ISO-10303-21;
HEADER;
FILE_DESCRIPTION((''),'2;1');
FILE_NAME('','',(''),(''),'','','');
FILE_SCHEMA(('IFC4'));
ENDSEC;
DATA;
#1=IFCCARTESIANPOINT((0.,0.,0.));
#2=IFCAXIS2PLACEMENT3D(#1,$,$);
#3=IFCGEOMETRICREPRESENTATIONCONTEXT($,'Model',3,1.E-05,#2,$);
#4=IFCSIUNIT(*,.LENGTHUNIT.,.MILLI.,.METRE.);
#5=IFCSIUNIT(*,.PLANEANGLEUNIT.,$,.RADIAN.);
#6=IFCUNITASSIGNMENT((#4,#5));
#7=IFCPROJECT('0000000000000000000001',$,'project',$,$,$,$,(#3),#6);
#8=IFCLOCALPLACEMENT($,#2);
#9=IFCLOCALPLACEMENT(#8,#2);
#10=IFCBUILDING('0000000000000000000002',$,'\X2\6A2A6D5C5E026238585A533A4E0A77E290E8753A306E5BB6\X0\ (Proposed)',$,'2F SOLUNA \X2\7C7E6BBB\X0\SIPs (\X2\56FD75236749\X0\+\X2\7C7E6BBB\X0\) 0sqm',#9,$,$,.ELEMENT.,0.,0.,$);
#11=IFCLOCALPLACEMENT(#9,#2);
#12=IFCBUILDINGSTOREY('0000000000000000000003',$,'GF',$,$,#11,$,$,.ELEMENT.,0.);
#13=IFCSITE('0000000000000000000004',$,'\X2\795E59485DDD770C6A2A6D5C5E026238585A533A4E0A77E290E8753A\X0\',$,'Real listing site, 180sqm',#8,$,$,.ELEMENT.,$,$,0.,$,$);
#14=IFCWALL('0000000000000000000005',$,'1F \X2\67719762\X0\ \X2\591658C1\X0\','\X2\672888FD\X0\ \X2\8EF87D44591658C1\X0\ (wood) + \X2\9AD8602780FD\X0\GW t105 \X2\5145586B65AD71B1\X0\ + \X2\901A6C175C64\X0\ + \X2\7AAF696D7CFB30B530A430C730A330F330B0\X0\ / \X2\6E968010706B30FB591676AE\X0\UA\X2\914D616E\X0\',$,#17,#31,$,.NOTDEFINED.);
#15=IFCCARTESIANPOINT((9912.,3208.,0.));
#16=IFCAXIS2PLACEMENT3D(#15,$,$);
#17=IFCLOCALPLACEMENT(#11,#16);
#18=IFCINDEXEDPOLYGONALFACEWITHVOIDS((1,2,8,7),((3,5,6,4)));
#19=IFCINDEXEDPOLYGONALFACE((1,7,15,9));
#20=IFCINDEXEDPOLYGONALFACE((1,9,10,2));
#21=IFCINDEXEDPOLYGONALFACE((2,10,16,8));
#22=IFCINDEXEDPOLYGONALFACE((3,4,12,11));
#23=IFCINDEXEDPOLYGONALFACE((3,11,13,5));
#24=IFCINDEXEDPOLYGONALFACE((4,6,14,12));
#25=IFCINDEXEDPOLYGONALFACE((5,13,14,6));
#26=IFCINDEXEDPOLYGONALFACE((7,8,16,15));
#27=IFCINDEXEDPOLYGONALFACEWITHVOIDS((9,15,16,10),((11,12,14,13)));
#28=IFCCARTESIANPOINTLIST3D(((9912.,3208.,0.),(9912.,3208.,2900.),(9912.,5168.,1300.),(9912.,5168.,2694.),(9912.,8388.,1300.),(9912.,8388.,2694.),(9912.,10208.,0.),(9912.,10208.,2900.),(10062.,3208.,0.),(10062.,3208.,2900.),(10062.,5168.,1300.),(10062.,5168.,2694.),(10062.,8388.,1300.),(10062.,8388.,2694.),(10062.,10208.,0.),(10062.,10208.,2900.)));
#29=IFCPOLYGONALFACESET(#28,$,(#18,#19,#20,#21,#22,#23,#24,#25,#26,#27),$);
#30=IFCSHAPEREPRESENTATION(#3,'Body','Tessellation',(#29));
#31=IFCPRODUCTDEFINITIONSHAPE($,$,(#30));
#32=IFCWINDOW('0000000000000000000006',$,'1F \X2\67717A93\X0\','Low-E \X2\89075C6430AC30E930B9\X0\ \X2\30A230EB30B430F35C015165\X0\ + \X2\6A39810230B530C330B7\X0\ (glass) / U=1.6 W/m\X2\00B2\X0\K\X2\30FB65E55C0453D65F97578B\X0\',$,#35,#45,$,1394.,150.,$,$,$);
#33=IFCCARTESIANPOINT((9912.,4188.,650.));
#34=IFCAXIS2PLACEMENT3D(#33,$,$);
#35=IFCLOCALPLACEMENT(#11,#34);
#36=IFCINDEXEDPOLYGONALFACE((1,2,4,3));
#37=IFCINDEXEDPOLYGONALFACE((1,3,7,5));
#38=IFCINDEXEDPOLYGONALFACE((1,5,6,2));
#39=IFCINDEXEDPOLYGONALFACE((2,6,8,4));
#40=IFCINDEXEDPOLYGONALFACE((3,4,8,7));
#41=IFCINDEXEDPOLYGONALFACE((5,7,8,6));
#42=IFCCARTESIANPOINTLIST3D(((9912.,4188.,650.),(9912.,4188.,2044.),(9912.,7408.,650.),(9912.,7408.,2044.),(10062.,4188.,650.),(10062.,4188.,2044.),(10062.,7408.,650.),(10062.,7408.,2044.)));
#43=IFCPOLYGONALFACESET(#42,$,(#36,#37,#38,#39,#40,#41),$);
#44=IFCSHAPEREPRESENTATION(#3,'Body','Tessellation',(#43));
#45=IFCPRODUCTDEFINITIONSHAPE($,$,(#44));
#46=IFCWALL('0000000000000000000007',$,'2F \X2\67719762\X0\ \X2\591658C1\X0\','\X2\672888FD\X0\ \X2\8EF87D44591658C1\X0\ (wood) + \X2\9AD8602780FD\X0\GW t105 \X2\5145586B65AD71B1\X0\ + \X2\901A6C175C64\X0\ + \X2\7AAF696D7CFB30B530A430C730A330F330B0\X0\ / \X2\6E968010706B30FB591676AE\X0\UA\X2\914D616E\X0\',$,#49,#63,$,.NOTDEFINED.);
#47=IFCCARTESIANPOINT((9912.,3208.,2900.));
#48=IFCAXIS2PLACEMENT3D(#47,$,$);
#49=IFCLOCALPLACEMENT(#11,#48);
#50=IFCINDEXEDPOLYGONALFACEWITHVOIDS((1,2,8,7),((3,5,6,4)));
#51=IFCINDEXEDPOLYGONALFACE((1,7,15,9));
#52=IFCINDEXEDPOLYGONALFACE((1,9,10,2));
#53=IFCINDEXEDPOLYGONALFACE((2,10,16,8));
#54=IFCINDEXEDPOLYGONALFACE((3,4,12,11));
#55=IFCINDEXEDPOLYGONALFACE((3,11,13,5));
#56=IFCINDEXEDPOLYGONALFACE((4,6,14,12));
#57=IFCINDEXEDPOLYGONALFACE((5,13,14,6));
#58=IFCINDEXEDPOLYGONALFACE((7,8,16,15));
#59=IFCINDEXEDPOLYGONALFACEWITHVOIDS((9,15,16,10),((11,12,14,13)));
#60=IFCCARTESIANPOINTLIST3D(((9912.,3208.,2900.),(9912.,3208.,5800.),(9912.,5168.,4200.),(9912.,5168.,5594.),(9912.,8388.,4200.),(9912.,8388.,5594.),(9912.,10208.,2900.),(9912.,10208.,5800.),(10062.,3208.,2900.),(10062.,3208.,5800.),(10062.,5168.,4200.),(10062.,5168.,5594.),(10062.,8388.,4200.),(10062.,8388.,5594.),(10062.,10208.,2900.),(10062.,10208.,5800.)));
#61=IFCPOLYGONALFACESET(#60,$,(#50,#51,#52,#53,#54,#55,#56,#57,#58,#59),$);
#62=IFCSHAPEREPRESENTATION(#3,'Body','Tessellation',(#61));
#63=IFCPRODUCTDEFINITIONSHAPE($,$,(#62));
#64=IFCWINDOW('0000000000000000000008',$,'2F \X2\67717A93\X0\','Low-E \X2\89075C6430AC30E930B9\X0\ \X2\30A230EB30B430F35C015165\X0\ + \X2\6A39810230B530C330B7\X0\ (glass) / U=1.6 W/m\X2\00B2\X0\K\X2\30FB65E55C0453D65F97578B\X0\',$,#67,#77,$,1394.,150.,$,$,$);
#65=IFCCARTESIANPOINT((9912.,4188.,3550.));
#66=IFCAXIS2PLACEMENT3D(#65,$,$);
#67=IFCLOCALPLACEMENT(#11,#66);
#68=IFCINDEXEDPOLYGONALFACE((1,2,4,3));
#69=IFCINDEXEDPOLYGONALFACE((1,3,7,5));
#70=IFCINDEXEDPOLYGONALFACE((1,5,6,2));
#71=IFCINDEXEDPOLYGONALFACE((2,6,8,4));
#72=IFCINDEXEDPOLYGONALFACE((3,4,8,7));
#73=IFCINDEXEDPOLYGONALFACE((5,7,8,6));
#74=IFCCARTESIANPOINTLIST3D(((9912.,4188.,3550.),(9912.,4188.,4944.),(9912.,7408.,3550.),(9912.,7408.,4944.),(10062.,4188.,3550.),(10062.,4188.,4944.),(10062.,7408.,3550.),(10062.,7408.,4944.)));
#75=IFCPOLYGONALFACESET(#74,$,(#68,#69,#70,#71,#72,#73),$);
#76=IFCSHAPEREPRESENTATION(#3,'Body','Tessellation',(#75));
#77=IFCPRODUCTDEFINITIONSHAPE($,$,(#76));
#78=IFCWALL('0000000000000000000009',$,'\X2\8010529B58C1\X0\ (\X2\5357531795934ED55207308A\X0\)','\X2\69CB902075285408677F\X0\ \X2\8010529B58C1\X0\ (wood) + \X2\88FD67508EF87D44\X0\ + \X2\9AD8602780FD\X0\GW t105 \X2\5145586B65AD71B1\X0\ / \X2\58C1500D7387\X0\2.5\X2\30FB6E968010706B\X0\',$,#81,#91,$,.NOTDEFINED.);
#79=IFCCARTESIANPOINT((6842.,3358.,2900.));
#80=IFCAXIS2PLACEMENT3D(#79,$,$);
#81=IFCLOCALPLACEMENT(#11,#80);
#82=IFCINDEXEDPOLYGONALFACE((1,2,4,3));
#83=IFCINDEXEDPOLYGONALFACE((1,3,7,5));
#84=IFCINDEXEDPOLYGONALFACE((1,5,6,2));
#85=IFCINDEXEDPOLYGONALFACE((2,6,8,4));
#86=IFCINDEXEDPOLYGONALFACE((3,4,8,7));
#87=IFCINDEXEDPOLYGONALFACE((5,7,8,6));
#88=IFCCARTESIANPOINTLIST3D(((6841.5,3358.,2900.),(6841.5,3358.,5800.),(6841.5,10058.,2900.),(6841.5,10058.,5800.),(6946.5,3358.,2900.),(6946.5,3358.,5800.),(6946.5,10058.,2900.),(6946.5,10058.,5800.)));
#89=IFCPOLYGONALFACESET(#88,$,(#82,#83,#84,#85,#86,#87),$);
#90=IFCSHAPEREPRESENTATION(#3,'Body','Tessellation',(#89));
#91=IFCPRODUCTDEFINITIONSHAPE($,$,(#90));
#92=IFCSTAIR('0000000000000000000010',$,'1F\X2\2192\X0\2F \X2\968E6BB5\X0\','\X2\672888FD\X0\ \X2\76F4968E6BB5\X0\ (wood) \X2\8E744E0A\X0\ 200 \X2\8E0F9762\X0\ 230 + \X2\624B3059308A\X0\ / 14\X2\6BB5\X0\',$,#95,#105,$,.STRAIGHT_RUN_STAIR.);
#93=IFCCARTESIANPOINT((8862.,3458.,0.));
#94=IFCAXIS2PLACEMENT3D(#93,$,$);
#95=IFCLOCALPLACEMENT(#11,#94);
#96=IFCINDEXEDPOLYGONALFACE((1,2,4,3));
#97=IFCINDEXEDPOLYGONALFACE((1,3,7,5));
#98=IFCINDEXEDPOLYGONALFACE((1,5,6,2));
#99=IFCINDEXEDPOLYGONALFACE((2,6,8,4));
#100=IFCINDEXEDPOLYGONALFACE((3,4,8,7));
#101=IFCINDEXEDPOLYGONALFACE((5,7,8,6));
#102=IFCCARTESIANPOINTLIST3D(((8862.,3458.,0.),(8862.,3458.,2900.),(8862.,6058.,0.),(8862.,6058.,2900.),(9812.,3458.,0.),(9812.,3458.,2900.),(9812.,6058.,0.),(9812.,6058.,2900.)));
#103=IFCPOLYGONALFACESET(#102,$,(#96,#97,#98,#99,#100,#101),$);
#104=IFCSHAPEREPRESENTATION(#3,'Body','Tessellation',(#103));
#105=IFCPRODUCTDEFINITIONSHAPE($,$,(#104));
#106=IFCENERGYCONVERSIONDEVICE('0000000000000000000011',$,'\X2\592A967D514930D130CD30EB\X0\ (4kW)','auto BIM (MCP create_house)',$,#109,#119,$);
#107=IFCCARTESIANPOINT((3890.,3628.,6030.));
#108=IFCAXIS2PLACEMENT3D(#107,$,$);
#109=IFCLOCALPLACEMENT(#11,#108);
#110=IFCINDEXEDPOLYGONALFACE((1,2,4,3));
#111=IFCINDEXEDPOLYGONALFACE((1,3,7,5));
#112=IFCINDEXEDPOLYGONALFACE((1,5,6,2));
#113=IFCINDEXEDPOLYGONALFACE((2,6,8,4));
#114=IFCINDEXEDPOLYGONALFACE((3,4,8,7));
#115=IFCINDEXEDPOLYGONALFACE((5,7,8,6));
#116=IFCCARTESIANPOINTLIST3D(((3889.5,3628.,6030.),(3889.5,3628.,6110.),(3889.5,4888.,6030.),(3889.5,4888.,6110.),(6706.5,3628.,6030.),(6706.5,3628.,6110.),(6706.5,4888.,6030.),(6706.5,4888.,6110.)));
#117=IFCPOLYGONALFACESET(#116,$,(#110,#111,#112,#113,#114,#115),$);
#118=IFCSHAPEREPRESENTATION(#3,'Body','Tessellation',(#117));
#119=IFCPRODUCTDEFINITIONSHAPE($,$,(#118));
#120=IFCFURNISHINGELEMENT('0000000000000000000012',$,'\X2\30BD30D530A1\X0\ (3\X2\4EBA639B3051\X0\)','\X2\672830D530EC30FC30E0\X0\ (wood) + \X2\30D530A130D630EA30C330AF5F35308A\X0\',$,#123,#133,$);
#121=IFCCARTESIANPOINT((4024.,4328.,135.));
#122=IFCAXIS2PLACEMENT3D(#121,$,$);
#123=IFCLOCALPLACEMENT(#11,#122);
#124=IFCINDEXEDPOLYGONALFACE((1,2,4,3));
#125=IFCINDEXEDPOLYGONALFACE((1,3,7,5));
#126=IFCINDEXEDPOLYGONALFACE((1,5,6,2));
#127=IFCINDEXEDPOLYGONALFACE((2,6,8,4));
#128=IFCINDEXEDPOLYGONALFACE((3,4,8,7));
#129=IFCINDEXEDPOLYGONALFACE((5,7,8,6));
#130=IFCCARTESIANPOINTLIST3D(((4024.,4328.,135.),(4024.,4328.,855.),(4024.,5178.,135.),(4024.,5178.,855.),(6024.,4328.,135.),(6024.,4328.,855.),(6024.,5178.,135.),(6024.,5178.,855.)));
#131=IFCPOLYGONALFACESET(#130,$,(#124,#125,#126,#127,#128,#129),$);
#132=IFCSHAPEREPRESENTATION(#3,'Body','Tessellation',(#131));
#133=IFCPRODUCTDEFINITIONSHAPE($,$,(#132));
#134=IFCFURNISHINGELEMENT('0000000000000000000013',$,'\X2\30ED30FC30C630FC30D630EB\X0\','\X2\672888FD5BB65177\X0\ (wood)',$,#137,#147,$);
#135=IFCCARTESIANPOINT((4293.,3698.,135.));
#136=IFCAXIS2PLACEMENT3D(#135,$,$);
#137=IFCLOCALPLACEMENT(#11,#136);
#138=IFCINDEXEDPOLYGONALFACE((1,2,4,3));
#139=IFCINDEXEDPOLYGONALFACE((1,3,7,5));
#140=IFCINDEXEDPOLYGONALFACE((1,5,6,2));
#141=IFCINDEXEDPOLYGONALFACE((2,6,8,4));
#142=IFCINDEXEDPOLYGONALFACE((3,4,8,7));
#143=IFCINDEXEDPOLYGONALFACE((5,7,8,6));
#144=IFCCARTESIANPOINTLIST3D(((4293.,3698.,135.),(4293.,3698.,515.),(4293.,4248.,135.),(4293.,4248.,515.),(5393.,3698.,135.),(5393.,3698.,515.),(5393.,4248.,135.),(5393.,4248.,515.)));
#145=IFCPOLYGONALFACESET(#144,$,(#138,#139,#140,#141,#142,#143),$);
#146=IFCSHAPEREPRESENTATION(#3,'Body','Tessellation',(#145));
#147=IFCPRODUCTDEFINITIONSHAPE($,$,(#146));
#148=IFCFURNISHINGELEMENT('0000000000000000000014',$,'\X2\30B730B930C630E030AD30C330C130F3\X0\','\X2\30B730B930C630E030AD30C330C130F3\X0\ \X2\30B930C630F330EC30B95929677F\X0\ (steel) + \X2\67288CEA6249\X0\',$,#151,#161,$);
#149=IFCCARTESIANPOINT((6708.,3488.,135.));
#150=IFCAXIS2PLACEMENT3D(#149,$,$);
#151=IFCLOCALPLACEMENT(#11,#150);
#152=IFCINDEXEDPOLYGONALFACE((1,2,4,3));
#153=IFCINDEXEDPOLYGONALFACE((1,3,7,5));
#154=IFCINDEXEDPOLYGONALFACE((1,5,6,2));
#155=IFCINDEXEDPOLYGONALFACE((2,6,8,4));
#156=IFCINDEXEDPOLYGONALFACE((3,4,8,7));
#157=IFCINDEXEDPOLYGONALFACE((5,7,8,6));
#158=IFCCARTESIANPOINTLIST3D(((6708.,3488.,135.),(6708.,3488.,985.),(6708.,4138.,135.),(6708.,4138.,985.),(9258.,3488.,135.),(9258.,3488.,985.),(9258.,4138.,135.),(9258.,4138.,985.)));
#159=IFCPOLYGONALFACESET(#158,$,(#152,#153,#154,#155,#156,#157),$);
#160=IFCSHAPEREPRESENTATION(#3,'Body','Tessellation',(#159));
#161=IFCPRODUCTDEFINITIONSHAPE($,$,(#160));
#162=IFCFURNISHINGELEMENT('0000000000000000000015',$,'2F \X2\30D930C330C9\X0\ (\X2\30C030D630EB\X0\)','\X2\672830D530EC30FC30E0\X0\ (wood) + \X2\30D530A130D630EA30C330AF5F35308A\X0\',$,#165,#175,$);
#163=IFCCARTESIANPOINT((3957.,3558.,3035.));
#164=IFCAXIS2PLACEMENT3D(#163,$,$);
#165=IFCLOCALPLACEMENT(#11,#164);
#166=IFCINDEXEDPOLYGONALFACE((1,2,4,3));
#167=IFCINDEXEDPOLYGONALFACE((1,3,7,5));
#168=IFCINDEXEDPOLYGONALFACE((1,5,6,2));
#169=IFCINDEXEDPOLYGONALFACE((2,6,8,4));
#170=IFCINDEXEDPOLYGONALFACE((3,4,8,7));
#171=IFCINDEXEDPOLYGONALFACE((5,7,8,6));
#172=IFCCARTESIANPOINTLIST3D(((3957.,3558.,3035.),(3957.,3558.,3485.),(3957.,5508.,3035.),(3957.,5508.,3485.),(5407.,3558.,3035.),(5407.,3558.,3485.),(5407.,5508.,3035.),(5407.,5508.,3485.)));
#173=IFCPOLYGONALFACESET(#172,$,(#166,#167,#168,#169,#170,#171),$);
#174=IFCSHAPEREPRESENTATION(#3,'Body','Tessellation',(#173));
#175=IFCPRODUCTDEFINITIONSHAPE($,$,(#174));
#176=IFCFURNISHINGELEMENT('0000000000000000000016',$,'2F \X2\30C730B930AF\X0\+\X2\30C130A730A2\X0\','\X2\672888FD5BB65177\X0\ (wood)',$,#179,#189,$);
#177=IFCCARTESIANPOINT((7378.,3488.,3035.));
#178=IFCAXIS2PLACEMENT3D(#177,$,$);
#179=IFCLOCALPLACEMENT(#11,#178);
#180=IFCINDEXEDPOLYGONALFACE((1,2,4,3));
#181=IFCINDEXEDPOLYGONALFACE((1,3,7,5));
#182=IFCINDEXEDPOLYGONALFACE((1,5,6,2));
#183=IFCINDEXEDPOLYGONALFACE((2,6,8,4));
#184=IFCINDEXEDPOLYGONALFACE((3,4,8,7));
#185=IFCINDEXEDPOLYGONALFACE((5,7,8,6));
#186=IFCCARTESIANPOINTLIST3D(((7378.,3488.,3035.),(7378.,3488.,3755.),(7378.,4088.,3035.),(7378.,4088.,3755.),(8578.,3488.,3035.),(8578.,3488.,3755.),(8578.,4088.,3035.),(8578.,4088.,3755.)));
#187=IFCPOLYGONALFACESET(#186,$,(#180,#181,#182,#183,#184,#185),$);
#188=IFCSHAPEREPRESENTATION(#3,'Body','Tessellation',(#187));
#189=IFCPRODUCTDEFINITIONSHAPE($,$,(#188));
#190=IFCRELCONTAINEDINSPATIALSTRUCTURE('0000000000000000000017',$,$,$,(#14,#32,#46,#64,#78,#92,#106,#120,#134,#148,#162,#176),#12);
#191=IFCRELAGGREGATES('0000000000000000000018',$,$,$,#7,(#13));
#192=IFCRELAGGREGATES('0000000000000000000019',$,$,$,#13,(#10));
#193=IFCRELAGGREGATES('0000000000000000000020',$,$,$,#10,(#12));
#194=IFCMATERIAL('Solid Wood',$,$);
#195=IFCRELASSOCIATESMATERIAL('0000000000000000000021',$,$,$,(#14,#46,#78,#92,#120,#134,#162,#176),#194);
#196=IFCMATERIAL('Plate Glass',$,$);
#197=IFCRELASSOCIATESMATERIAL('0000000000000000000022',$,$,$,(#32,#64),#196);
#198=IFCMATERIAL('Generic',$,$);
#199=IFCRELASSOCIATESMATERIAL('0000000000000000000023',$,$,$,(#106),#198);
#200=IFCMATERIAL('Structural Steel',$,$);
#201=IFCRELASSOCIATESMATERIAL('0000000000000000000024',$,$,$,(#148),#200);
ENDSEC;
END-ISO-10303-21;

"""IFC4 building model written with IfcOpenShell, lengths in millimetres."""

from ifc_helpers import new_model, si_unit, frame, frame_2d, origin, place, context, project, spatial, rectangle, extrude, material, element, fill, save


model = new_model("IFC4")

# Units and contexts
model_context = context("Model", 3, precision=1e-05, world=origin())
ifc_project = project(units=[si_unit("LENGTHUNIT", "METRE", prefix="MILLI"), si_unit("PLANEANGLEUNIT", "RADIAN")], contexts=[model_context])

# Site, building, storey
site_placement = place(None, origin())
site = spatial("IfcSite", under=ifc_project, at=site_placement, Name="神奈川県横浜市戸塚区上矢部町", ObjectType="Real listing site, 180sqm", CompositionType="ELEMENT", RefElevation=0.0)
building_placement = place(site_placement, origin())
building = spatial("IfcBuilding", under=site, at=building_placement, Name="横浜市戸塚区上矢部町の家 (Proposed)", ObjectType="2F SOLUNA 籾殻SIPs (国産杉+籾殻) 0sqm", CompositionType="ELEMENT", ElevationOfRefHeight=0.0, ElevationOfTerrain=0.0)
storey_placement = place(building_placement, origin())
storey = spatial("IfcBuildingStorey", under=building, at=storey_placement, Name="GF", CompositionType="ELEMENT", Elevation=0.0)

# Wall, opening, window
ifc_material_1 = material(Name="Solid Wood")
wall_1_placement = place(storey_placement, frame((9912.0, 3208.0, 0.0)))
wall_1 = element("IfcWall", 1, at=wall_1_placement, inside=storey, material=ifc_material_1, Name="1F 東面 外壁", Description="木製 軸組外壁 (wood) + 高性能GW t105 充填断熱 + 通気層 + 窯業系サイディング / 準耐火・外皮UA配慮", PredefinedType="NOTDEFINED", context=model_context, shape_type="SweptSolid", body=[
    extrude(rectangle(XDim=150.0, YDim=7000.0, at=frame_2d((75.0, 3500.0))), frame((9912.0, 3208.0, 0.0)), (0.0, 0.0, 1.0), 2900.0),
])
opening_1_placement = place(storey_placement, frame((9912.0, 4188.0, 650.0)))
opening_1 = element("IfcOpeningElement", 2, at=opening_1_placement, cuts=wall_1, PredefinedType="NOTDEFINED", context=model_context, shape_type="SweptSolid", body=[
    extrude(rectangle(XDim=150.0, YDim=3220.0, at=frame_2d((75.0, 1610.0))), frame((9912.0, 4188.0, 650.0)), (0.0, 0.0, 1.0), 1394.0),
])
ifc_material_2 = material(Name="Plate Glass")
window_1_placement = place(storey_placement, frame((9912.0, 4188.0, 650.0)))
window_1 = element("IfcWindow", 3, at=window_1_placement, inside=storey, material=ifc_material_2, Name="1F 東窓", Description="Low-E 複層ガラス アルゴン封入 + 樹脂サッシ (glass) / U=1.6 W/m²K・日射取得型", OverallHeight=1394.0, OverallWidth=150.0, context=model_context, shape_type="SweptSolid", body=[
    extrude(rectangle(XDim=150.0, YDim=3220.0, at=frame_2d((75.0, 1610.0))), frame((9912.0, 4188.0, 650.0)), (0.0, 0.0, 1.0), 1394.0),
])
fill(opening_1, window_1)

# Wall, opening, window
wall_2_placement = place(storey_placement, frame((9912.0, 3208.0, 2900.0)))
wall_2 = element("IfcWall", 4, at=wall_2_placement, inside=storey, material=ifc_material_1, Name="2F 東面 外壁", Description="木製 軸組外壁 (wood) + 高性能GW t105 充填断熱 + 通気層 + 窯業系サイディング / 準耐火・外皮UA配慮", PredefinedType="NOTDEFINED", context=model_context, shape_type="SweptSolid", body=[
    extrude(rectangle(XDim=150.0, YDim=7000.0, at=frame_2d((75.0, 3500.0))), frame((9912.0, 3208.0, 2900.0)), (0.0, 0.0, 1.0), 2900.0),
])
opening_2_placement = place(storey_placement, frame((9912.0, 4188.0, 3550.0)))
opening_2 = element("IfcOpeningElement", 5, at=opening_2_placement, cuts=wall_2, PredefinedType="NOTDEFINED", context=model_context, shape_type="SweptSolid", body=[
    extrude(rectangle(XDim=150.0, YDim=3220.0, at=frame_2d((75.0, 1610.0))), frame((9912.0, 4188.0, 3550.0)), (0.0, 0.0, 1.0), 1394.0),
])
window_2_placement = place(storey_placement, frame((9912.0, 4188.0, 3550.0)))
window_2 = element("IfcWindow", 6, at=window_2_placement, inside=storey, material=ifc_material_2, Name="2F 東窓", Description="Low-E 複層ガラス アルゴン封入 + 樹脂サッシ (glass) / U=1.6 W/m²K・日射取得型", OverallHeight=1394.0, OverallWidth=150.0, context=model_context, shape_type="SweptSolid", body=[
    extrude(rectangle(XDim=150.0, YDim=3220.0, at=frame_2d((75.0, 1610.0))), frame((9912.0, 4188.0, 3550.0)), (0.0, 0.0, 1.0), 1394.0),
])
fill(opening_2, window_2)

# Wall
wall_3_placement = place(storey_placement, frame((6842.0, 3358.0, 2900.0)))
element("IfcWall", 7, at=wall_3_placement, inside=storey, material=ifc_material_1, Name="耐力壁 (南北間仕切り)", Description="構造用合板 耐力壁 (wood) + 製材軸組 + 高性能GW t105 充填断熱 / 壁倍率2.5・準耐火", PredefinedType="NOTDEFINED", context=model_context, shape_type="SweptSolid", body=[
    extrude(rectangle(XDim=105.0, YDim=6700.0, at=frame_2d((52.0, 3350.0))), frame((6842.0, 3358.0, 2900.0)), (0.0, 0.0, 1.0), 2900.0),
])

# Stair
stair_placement = place(storey_placement, frame((8862.0, 3458.0, 0.0)))
element("IfcStair", 8, at=stair_placement, inside=storey, material=ifc_material_1, Name="1F→2F 階段", Description="木製 直階段 (wood) 蹴上 200 踏面 230 + 手すり / 14段", PredefinedType="STRAIGHT_RUN_STAIR", context=model_context, shape_type="SweptSolid", body=[
    extrude(rectangle(XDim=950.0, YDim=2600.0, at=frame_2d((475.0, 1300.0))), frame((8862.0, 3458.0, 0.0)), (0.0, 0.0, 1.0), 2900.0),
])

# Energy conversion device
ifc_material_3 = material(Name="Generic")
energy_conversion_device_placement = place(storey_placement, frame((3890.0, 3628.0, 6030.0)))
element("IfcEnergyConversionDevice", 9, at=energy_conversion_device_placement, inside=storey, material=ifc_material_3, Name="太陽光パネル (4kW)", Description="auto BIM (MCP create_house)", context=model_context, shape_type="SweptSolid", body=[
    extrude(rectangle(XDim=2817.0, YDim=1260.0, at=frame_2d((1408.0, 630.0))), frame((3890.0, 3628.0, 6030.0)), (0.0, 0.0, 1.0), 80.0),
])

# Furnishing elements
furnishing_1_placement = place(storey_placement, frame((4024.0, 4328.0, 135.0)))
element("IfcFurnishingElement", 10, at=furnishing_1_placement, inside=storey, material=ifc_material_1, Name="ソファ (3人掛け)", Description="木フレーム (wood) + ファブリック張り", context=model_context, shape_type="SweptSolid", body=[
    extrude(rectangle(XDim=2000.0, YDim=850.0, at=frame_2d((1000.0, 425.0))), frame((4024.0, 4328.0, 135.0)), (0.0, 0.0, 1.0), 720.0),
])
furnishing_2_placement = place(storey_placement, frame((4293.0, 3698.0, 135.0)))
element("IfcFurnishingElement", 11, at=furnishing_2_placement, inside=storey, material=ifc_material_1, Name="ローテーブル", Description="木製家具 (wood)", context=model_context, shape_type="SweptSolid", body=[
    extrude(rectangle(XDim=1100.0, YDim=550.0, at=frame_2d((550.0, 275.0))), frame((4293.0, 3698.0, 135.0)), (0.0, 0.0, 1.0), 380.0),
])
ifc_material_4 = material(Name="Structural Steel")
furnishing_3_placement = place(storey_placement, frame((6708.0, 3488.0, 135.0)))
element("IfcFurnishingElement", 12, at=furnishing_3_placement, inside=storey, material=ifc_material_4, Name="システムキッチン", Description="システムキッチン ステンレス天板 (steel) + 木質扉", context=model_context, shape_type="SweptSolid", body=[
    extrude(rectangle(XDim=2550.0, YDim=650.0, at=frame_2d((1275.0, 325.0))), frame((6708.0, 3488.0, 135.0)), (0.0, 0.0, 1.0), 850.0),
])
furnishing_4_placement = place(storey_placement, frame((3957.0, 3558.0, 3035.0)))
element("IfcFurnishingElement", 13, at=furnishing_4_placement, inside=storey, material=ifc_material_1, Name="2F ベッド (ダブル)", Description="木フレーム (wood) + ファブリック張り", context=model_context, shape_type="SweptSolid", body=[
    extrude(rectangle(XDim=1450.0, YDim=1950.0, at=frame_2d((725.0, 975.0))), frame((3957.0, 3558.0, 3035.0)), (0.0, 0.0, 1.0), 450.0),
])
furnishing_5_placement = place(storey_placement, frame((7378.0, 3488.0, 3035.0)))
element("IfcFurnishingElement", 14, at=furnishing_5_placement, inside=storey, material=ifc_material_1, Name="2F デスク+チェア", Description="木製家具 (wood)", context=model_context, shape_type="SweptSolid", body=[
    extrude(rectangle(XDim=1200.0, YDim=600.0, at=frame_2d((600.0, 300.0))), frame((7378.0, 3488.0, 3035.0)), (0.0, 0.0, 1.0), 720.0),
])

save(model, "model.ifc")
